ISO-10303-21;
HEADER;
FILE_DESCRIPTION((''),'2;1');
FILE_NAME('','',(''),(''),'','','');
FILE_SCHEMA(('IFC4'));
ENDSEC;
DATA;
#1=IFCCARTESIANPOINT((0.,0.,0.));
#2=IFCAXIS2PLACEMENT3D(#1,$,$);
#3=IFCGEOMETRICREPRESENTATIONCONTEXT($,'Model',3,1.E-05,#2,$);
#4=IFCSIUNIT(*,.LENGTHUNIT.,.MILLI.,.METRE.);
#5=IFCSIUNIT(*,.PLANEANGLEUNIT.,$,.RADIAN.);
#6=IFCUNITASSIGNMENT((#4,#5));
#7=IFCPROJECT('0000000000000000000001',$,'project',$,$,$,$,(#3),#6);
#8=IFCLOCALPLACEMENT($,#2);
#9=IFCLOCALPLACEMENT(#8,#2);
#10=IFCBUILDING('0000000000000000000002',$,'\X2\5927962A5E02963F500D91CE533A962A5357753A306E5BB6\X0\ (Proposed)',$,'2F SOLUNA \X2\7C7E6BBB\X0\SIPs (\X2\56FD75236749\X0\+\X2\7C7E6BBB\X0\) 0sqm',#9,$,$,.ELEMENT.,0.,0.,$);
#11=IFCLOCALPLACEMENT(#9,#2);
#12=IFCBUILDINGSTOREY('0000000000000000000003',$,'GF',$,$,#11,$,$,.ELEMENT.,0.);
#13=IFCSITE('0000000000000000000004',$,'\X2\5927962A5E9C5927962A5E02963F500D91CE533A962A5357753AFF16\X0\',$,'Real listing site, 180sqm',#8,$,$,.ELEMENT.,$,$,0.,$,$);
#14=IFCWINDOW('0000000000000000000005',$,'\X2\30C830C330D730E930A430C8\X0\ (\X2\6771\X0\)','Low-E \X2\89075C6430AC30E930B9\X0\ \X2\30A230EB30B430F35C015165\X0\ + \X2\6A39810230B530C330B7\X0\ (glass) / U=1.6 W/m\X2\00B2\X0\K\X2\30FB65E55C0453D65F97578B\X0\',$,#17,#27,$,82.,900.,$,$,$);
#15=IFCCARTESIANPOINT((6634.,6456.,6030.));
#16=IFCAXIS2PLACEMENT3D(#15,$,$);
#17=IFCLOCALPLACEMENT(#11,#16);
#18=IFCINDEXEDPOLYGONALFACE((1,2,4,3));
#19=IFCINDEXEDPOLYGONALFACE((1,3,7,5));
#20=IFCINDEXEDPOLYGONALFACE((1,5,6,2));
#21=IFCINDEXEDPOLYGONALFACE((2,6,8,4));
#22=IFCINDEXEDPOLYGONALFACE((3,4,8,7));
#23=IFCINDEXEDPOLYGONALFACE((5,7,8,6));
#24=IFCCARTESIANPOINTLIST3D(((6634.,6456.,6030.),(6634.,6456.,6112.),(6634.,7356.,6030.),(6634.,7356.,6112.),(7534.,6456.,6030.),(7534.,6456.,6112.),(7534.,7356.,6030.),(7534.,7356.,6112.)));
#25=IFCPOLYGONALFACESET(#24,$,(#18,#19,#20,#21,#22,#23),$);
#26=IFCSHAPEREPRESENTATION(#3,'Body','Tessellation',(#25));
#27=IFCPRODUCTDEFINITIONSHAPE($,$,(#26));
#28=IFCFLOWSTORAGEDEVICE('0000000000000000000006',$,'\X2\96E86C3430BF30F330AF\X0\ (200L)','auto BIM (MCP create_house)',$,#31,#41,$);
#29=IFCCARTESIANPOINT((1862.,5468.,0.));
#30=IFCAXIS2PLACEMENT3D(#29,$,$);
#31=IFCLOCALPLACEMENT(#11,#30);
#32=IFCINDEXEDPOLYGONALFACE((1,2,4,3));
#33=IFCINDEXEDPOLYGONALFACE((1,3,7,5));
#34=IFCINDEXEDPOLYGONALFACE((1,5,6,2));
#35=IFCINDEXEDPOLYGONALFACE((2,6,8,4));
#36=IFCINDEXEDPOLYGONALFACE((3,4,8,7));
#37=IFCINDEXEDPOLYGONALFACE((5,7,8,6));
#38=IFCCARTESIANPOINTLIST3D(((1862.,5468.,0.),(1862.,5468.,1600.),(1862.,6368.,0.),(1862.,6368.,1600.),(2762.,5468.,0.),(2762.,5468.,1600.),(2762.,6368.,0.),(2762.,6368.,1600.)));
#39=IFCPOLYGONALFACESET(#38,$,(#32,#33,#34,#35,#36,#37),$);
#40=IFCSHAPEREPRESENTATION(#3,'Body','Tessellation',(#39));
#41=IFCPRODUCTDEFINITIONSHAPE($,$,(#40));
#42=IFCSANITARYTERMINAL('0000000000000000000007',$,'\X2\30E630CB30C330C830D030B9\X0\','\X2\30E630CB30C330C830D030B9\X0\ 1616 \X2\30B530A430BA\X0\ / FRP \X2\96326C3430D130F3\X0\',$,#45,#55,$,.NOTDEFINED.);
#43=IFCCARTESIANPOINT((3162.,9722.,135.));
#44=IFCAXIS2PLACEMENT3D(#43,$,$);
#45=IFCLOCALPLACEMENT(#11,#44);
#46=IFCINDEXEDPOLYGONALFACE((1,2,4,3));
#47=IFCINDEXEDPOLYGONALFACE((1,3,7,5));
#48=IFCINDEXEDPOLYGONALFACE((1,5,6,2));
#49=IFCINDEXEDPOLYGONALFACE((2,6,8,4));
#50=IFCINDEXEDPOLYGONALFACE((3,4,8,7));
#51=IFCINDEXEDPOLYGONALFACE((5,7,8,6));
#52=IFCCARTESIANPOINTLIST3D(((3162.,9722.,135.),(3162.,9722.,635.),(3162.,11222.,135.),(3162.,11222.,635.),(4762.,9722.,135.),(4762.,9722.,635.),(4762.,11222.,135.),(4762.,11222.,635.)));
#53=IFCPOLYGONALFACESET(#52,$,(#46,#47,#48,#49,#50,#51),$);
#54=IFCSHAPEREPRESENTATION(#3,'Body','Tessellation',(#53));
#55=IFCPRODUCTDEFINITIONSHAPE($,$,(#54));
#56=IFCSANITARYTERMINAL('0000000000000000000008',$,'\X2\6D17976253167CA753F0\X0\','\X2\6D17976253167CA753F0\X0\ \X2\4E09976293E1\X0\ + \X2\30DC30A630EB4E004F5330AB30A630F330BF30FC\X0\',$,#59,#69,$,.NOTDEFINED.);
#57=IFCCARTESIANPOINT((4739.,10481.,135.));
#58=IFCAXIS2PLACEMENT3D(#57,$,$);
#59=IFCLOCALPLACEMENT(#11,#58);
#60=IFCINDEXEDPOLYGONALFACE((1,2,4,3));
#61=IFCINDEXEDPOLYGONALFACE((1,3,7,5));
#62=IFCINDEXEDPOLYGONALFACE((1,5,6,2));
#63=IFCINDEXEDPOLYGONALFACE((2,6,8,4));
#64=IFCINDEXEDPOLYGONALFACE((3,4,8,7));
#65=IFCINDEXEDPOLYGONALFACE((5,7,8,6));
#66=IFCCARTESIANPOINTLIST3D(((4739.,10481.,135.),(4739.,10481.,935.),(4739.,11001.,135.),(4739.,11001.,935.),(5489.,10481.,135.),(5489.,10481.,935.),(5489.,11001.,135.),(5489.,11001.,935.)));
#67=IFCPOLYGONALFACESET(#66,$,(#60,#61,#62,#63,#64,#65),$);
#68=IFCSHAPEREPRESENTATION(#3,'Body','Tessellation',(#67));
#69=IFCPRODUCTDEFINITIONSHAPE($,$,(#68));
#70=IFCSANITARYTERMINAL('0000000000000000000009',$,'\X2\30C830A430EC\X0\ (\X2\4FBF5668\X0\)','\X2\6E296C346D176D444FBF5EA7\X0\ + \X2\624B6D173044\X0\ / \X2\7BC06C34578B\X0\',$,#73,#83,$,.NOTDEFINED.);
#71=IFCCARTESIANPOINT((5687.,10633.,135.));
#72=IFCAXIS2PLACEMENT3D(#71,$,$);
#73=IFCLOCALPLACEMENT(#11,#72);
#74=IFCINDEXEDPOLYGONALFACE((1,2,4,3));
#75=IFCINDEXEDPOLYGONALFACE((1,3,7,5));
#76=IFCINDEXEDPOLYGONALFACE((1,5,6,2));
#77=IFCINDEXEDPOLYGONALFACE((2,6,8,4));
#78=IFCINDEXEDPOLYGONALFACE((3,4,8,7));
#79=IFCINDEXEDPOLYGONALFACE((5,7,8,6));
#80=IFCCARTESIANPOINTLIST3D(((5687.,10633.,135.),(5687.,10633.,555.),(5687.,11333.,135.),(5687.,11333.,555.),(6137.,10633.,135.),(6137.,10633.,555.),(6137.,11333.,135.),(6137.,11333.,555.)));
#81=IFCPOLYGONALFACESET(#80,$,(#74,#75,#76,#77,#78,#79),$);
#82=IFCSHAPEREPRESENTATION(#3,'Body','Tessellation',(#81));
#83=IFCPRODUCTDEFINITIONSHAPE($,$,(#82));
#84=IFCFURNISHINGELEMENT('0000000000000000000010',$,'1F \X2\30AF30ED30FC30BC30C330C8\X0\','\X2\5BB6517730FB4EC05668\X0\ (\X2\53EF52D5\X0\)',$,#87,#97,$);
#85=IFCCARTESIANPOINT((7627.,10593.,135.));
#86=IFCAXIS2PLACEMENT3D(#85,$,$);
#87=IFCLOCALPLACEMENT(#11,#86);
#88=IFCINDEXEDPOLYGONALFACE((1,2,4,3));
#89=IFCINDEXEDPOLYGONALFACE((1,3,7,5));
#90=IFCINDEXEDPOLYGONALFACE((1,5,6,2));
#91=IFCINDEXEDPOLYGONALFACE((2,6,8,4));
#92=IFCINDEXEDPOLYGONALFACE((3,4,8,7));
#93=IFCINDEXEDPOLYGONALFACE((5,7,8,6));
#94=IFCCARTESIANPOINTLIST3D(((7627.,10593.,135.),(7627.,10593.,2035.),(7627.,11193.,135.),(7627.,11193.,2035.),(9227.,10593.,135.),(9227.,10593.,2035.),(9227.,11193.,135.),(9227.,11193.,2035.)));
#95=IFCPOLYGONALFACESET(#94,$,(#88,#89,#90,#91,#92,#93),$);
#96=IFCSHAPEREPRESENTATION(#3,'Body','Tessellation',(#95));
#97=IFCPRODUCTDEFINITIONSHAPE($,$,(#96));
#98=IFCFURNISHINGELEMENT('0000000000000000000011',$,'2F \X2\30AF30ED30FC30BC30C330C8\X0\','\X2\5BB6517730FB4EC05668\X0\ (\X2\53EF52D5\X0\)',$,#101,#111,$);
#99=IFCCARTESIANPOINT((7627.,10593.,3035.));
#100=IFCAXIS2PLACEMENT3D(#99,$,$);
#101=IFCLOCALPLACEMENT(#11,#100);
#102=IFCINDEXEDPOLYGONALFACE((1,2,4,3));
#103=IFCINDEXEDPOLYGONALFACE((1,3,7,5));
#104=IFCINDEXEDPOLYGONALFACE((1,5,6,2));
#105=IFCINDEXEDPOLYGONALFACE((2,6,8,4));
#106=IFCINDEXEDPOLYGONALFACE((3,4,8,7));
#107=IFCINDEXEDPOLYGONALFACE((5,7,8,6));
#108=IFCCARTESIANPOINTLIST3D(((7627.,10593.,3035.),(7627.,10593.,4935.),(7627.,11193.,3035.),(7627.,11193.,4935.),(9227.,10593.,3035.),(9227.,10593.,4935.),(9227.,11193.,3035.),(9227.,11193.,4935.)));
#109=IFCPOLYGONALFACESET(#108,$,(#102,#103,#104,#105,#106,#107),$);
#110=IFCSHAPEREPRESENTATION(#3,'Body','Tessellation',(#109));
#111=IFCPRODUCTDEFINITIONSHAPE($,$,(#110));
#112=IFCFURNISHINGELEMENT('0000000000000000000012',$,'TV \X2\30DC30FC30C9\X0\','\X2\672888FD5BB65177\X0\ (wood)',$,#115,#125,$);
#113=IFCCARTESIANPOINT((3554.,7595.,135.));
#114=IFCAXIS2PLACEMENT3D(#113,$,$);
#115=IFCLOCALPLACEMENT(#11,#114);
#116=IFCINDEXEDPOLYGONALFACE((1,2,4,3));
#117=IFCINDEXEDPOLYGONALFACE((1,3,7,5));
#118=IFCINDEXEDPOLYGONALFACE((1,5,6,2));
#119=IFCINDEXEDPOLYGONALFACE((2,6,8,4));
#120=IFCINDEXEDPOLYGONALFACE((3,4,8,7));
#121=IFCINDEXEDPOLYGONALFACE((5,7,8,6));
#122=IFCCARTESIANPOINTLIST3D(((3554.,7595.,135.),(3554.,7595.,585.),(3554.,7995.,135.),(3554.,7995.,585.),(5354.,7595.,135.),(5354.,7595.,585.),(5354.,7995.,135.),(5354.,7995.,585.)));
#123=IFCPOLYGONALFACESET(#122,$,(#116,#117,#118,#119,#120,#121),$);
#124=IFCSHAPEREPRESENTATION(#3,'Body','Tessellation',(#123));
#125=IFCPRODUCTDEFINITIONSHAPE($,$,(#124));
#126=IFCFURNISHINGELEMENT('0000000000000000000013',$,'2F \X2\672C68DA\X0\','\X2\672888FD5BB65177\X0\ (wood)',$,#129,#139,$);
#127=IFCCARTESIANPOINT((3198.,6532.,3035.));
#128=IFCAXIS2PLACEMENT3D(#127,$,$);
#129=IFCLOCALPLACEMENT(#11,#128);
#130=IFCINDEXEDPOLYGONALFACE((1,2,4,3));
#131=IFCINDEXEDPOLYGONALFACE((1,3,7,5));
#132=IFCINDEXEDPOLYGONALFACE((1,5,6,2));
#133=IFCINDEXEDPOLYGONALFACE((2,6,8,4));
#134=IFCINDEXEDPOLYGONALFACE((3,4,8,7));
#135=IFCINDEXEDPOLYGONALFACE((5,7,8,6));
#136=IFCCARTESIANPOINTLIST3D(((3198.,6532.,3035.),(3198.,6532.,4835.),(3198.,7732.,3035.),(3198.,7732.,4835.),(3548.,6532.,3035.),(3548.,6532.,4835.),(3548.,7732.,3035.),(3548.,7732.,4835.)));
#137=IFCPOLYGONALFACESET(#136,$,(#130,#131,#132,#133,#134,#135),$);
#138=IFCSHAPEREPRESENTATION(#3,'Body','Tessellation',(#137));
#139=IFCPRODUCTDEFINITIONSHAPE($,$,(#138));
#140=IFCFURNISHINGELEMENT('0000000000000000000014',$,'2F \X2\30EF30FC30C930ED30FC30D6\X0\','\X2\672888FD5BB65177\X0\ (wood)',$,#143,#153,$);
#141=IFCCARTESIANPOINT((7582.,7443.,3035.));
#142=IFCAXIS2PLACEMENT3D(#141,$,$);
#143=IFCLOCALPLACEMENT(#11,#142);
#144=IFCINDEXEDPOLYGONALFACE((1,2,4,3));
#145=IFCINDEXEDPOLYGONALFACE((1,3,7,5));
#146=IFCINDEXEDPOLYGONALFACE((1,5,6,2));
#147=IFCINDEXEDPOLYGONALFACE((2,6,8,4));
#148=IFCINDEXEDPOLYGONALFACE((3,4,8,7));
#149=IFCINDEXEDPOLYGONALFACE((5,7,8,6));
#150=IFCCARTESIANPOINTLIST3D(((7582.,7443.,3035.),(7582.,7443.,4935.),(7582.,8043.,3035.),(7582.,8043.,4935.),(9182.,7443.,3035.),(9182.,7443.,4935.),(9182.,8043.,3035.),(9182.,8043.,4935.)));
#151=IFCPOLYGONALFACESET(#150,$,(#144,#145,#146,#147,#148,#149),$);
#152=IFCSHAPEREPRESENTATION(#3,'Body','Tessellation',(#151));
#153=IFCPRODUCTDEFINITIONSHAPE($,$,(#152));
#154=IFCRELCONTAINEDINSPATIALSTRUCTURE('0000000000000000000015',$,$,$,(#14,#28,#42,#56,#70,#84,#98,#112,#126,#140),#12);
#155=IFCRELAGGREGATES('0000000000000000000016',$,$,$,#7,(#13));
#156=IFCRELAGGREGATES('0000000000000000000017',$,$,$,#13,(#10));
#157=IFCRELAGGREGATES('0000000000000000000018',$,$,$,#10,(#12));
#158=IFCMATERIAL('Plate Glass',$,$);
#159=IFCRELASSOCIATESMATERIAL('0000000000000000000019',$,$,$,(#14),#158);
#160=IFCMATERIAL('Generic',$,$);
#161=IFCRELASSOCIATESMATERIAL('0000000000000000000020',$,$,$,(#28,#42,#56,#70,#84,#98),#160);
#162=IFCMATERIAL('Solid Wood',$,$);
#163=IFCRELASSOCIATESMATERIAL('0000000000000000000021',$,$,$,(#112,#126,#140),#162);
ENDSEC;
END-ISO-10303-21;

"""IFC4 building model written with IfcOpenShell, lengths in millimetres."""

from ifc_helpers import new_model, si_unit, frame, frame_2d, origin, place, context, project, spatial, rectangle, extrude, material, element, save


model = new_model("IFC4")

# Units and contexts
model_context = context("Model", 3, precision=1e-05, world=origin())
ifc_project = project(units=[si_unit("LENGTHUNIT", "METRE", prefix="MILLI"), si_unit("PLANEANGLEUNIT", "RADIAN")], contexts=[model_context])

# Site, building, storey
site_placement = place(None, origin())
site = spatial("IfcSite", under=ifc_project, at=site_placement, Name="大阪府大阪市阿倍野区阪南町６", ObjectType="Real listing site, 180sqm", CompositionType="ELEMENT", RefElevation=0.0)
building_placement = place(site_placement, origin())
building = spatial("IfcBuilding", under=site, at=building_placement, Name="大阪市阿倍野区阪南町の家 (Proposed)", ObjectType="2F SOLUNA 籾殻SIPs (国産杉+籾殻) 0sqm", CompositionType="ELEMENT", ElevationOfRefHeight=0.0, ElevationOfTerrain=0.0)
storey_placement = place(building_placement, origin())
storey = spatial("IfcBuildingStorey", under=building, at=storey_placement, Name="GF", CompositionType="ELEMENT", Elevation=0.0)

# Shared definitions
ifc_material_1 = material(Name="Solid Wood")
ifc_material_2 = material(Name="Plate Glass")

# Window
window_1_placement = place(storey_placement, frame((6634.0, 6456.0, 6030.0)))
element("IfcWindow", 1, at=window_1_placement, inside=storey, material=ifc_material_2, Name="トップライト (東)", Description="Low-E 複層ガラス アルゴン封入 + 樹脂サッシ (glass) / U=1.6 W/m²K・日射取得型", OverallHeight=82.0, OverallWidth=900.0, context=model_context, shape_type="SweptSolid", body=[
    extrude(rectangle(XDim=900.0, YDim=900.0, at=frame_2d((450.0, 450.0))), frame((6634.0, 6456.0, 6030.0)), (0.0, 0.0, 1.0), 82.0),
])

# Flow storage device
ifc_material_3 = material(Name="Generic")
flow_storage_device_placement = place(storey_placement, frame((1862.0, 5468.0, 0.0)))
element("IfcFlowStorageDevice", 2, at=flow_storage_device_placement, inside=storey, material=ifc_material_3, Name="雨水タンク (200L)", Description="auto BIM (MCP create_house)", context=model_context, shape_type="SweptSolid", body=[
    extrude(rectangle(XDim=900.0, YDim=900.0, at=frame_2d((450.0, 450.0))), frame((1862.0, 5468.0, 0.0)), (0.0, 0.0, 1.0), 1600.0),
])

# Sanitary terminals
sanitary_terminal_1_placement = place(storey_placement, frame((3162.0, 9722.0, 135.0)))
element("IfcSanitaryTerminal", 3, at=sanitary_terminal_1_placement, inside=storey, material=ifc_material_3, Name="ユニットバス", Description="ユニットバス 1616 サイズ / FRP 防水パン", PredefinedType="NOTDEFINED", context=model_context, shape_type="SweptSolid", body=[
    extrude(rectangle(XDim=1600.0, YDim=1500.0, at=frame_2d((800.0, 750.0))), frame((3162.0, 9722.0, 135.0)), (0.0, 0.0, 1.0), 500.0),
])
sanitary_terminal_2_placement = place(storey_placement, frame((4739.0, 10481.0, 135.0)))
element("IfcSanitaryTerminal", 4, at=sanitary_terminal_2_placement, inside=storey, material=ifc_material_3, Name="洗面化粧台", Description="洗面化粧台 三面鏡 + ボウル一体カウンター", PredefinedType="NOTDEFINED", context=model_context, shape_type="SweptSolid", body=[
    extrude(rectangle(XDim=750.0, YDim=520.0, at=frame_2d((375.0, 260.0))), frame((4739.0, 10481.0, 135.0)), (0.0, 0.0, 1.0), 800.0),
])
sanitary_terminal_3_placement = place(storey_placement, frame((5687.0, 10633.0, 135.0)))
element("IfcSanitaryTerminal", 5, at=sanitary_terminal_3_placement, inside=storey, material=ifc_material_3, Name="トイレ (便器)", Description="温水洗浄便座 + 手洗い / 節水型", PredefinedType="NOTDEFINED", context=model_context, shape_type="SweptSolid", body=[
    extrude(rectangle(XDim=450.0, YDim=700.0, at=frame_2d((225.0, 350.0))), frame((5687.0, 10633.0, 135.0)), (0.0, 0.0, 1.0), 420.0),
])

# Furnishing elements
furnishing_1_placement = place(storey_placement, frame((7627.0, 10593.0, 135.0)))
element("IfcFurnishingElement", 6, at=furnishing_1_placement, inside=storey, material=ifc_material_3, Name="1F クローゼット", Description="家具・什器 (可動)", context=model_context, shape_type="SweptSolid", body=[
    extrude(rectangle(XDim=1600.0, YDim=600.0, at=frame_2d((800.0, 300.0))), frame((7627.0, 10593.0, 135.0)), (0.0, 0.0, 1.0), 1900.0),
])
furnishing_2_placement = place(storey_placement, frame((7627.0, 10593.0, 3035.0)))
element("IfcFurnishingElement", 7, at=furnishing_2_placement, inside=storey, material=ifc_material_3, Name="2F クローゼット", Description="家具・什器 (可動)", context=model_context, shape_type="SweptSolid", body=[
    extrude(rectangle(XDim=1600.0, YDim=600.0, at=frame_2d((800.0, 300.0))), frame((7627.0, 10593.0, 3035.0)), (0.0, 0.0, 1.0), 1900.0),
])
furnishing_3_placement = place(storey_placement, frame((3554.0, 7595.0, 135.0)))
element("IfcFurnishingElement", 8, at=furnishing_3_placement, inside=storey, material=ifc_material_1, Name="TV ボード", Description="木製家具 (wood)", context=model_context, shape_type="SweptSolid", body=[
    extrude(rectangle(XDim=1800.0, YDim=400.0, at=frame_2d((900.0, 200.0))), frame((3554.0, 7595.0, 135.0)), (0.0, 0.0, 1.0), 450.0),
])
furnishing_4_placement = place(storey_placement, frame((3198.0, 6532.0, 3035.0)))
element("IfcFurnishingElement", 9, at=furnishing_4_placement, inside=storey, material=ifc_material_1, Name="2F 本棚", Description="木製家具 (wood)", context=model_context, shape_type="SweptSolid", body=[
    extrude(rectangle(XDim=350.0, YDim=1200.0, at=frame_2d((175.0, 600.0))), frame((3198.0, 6532.0, 3035.0)), (0.0, 0.0, 1.0), 1800.0),
])
furnishing_5_placement = place(storey_placement, frame((7582.0, 7443.0, 3035.0)))
element("IfcFurnishingElement", 10, at=furnishing_5_placement, inside=storey, material=ifc_material_1, Name="2F ワードローブ", Description="木製家具 (wood)", context=model_context, shape_type="SweptSolid", body=[
    extrude(rectangle(XDim=1600.0, YDim=600.0, at=frame_2d((800.0, 300.0))), frame((7582.0, 7443.0, 3035.0)), (0.0, 0.0, 1.0), 1900.0),
])

save(model, "model.ifc")
